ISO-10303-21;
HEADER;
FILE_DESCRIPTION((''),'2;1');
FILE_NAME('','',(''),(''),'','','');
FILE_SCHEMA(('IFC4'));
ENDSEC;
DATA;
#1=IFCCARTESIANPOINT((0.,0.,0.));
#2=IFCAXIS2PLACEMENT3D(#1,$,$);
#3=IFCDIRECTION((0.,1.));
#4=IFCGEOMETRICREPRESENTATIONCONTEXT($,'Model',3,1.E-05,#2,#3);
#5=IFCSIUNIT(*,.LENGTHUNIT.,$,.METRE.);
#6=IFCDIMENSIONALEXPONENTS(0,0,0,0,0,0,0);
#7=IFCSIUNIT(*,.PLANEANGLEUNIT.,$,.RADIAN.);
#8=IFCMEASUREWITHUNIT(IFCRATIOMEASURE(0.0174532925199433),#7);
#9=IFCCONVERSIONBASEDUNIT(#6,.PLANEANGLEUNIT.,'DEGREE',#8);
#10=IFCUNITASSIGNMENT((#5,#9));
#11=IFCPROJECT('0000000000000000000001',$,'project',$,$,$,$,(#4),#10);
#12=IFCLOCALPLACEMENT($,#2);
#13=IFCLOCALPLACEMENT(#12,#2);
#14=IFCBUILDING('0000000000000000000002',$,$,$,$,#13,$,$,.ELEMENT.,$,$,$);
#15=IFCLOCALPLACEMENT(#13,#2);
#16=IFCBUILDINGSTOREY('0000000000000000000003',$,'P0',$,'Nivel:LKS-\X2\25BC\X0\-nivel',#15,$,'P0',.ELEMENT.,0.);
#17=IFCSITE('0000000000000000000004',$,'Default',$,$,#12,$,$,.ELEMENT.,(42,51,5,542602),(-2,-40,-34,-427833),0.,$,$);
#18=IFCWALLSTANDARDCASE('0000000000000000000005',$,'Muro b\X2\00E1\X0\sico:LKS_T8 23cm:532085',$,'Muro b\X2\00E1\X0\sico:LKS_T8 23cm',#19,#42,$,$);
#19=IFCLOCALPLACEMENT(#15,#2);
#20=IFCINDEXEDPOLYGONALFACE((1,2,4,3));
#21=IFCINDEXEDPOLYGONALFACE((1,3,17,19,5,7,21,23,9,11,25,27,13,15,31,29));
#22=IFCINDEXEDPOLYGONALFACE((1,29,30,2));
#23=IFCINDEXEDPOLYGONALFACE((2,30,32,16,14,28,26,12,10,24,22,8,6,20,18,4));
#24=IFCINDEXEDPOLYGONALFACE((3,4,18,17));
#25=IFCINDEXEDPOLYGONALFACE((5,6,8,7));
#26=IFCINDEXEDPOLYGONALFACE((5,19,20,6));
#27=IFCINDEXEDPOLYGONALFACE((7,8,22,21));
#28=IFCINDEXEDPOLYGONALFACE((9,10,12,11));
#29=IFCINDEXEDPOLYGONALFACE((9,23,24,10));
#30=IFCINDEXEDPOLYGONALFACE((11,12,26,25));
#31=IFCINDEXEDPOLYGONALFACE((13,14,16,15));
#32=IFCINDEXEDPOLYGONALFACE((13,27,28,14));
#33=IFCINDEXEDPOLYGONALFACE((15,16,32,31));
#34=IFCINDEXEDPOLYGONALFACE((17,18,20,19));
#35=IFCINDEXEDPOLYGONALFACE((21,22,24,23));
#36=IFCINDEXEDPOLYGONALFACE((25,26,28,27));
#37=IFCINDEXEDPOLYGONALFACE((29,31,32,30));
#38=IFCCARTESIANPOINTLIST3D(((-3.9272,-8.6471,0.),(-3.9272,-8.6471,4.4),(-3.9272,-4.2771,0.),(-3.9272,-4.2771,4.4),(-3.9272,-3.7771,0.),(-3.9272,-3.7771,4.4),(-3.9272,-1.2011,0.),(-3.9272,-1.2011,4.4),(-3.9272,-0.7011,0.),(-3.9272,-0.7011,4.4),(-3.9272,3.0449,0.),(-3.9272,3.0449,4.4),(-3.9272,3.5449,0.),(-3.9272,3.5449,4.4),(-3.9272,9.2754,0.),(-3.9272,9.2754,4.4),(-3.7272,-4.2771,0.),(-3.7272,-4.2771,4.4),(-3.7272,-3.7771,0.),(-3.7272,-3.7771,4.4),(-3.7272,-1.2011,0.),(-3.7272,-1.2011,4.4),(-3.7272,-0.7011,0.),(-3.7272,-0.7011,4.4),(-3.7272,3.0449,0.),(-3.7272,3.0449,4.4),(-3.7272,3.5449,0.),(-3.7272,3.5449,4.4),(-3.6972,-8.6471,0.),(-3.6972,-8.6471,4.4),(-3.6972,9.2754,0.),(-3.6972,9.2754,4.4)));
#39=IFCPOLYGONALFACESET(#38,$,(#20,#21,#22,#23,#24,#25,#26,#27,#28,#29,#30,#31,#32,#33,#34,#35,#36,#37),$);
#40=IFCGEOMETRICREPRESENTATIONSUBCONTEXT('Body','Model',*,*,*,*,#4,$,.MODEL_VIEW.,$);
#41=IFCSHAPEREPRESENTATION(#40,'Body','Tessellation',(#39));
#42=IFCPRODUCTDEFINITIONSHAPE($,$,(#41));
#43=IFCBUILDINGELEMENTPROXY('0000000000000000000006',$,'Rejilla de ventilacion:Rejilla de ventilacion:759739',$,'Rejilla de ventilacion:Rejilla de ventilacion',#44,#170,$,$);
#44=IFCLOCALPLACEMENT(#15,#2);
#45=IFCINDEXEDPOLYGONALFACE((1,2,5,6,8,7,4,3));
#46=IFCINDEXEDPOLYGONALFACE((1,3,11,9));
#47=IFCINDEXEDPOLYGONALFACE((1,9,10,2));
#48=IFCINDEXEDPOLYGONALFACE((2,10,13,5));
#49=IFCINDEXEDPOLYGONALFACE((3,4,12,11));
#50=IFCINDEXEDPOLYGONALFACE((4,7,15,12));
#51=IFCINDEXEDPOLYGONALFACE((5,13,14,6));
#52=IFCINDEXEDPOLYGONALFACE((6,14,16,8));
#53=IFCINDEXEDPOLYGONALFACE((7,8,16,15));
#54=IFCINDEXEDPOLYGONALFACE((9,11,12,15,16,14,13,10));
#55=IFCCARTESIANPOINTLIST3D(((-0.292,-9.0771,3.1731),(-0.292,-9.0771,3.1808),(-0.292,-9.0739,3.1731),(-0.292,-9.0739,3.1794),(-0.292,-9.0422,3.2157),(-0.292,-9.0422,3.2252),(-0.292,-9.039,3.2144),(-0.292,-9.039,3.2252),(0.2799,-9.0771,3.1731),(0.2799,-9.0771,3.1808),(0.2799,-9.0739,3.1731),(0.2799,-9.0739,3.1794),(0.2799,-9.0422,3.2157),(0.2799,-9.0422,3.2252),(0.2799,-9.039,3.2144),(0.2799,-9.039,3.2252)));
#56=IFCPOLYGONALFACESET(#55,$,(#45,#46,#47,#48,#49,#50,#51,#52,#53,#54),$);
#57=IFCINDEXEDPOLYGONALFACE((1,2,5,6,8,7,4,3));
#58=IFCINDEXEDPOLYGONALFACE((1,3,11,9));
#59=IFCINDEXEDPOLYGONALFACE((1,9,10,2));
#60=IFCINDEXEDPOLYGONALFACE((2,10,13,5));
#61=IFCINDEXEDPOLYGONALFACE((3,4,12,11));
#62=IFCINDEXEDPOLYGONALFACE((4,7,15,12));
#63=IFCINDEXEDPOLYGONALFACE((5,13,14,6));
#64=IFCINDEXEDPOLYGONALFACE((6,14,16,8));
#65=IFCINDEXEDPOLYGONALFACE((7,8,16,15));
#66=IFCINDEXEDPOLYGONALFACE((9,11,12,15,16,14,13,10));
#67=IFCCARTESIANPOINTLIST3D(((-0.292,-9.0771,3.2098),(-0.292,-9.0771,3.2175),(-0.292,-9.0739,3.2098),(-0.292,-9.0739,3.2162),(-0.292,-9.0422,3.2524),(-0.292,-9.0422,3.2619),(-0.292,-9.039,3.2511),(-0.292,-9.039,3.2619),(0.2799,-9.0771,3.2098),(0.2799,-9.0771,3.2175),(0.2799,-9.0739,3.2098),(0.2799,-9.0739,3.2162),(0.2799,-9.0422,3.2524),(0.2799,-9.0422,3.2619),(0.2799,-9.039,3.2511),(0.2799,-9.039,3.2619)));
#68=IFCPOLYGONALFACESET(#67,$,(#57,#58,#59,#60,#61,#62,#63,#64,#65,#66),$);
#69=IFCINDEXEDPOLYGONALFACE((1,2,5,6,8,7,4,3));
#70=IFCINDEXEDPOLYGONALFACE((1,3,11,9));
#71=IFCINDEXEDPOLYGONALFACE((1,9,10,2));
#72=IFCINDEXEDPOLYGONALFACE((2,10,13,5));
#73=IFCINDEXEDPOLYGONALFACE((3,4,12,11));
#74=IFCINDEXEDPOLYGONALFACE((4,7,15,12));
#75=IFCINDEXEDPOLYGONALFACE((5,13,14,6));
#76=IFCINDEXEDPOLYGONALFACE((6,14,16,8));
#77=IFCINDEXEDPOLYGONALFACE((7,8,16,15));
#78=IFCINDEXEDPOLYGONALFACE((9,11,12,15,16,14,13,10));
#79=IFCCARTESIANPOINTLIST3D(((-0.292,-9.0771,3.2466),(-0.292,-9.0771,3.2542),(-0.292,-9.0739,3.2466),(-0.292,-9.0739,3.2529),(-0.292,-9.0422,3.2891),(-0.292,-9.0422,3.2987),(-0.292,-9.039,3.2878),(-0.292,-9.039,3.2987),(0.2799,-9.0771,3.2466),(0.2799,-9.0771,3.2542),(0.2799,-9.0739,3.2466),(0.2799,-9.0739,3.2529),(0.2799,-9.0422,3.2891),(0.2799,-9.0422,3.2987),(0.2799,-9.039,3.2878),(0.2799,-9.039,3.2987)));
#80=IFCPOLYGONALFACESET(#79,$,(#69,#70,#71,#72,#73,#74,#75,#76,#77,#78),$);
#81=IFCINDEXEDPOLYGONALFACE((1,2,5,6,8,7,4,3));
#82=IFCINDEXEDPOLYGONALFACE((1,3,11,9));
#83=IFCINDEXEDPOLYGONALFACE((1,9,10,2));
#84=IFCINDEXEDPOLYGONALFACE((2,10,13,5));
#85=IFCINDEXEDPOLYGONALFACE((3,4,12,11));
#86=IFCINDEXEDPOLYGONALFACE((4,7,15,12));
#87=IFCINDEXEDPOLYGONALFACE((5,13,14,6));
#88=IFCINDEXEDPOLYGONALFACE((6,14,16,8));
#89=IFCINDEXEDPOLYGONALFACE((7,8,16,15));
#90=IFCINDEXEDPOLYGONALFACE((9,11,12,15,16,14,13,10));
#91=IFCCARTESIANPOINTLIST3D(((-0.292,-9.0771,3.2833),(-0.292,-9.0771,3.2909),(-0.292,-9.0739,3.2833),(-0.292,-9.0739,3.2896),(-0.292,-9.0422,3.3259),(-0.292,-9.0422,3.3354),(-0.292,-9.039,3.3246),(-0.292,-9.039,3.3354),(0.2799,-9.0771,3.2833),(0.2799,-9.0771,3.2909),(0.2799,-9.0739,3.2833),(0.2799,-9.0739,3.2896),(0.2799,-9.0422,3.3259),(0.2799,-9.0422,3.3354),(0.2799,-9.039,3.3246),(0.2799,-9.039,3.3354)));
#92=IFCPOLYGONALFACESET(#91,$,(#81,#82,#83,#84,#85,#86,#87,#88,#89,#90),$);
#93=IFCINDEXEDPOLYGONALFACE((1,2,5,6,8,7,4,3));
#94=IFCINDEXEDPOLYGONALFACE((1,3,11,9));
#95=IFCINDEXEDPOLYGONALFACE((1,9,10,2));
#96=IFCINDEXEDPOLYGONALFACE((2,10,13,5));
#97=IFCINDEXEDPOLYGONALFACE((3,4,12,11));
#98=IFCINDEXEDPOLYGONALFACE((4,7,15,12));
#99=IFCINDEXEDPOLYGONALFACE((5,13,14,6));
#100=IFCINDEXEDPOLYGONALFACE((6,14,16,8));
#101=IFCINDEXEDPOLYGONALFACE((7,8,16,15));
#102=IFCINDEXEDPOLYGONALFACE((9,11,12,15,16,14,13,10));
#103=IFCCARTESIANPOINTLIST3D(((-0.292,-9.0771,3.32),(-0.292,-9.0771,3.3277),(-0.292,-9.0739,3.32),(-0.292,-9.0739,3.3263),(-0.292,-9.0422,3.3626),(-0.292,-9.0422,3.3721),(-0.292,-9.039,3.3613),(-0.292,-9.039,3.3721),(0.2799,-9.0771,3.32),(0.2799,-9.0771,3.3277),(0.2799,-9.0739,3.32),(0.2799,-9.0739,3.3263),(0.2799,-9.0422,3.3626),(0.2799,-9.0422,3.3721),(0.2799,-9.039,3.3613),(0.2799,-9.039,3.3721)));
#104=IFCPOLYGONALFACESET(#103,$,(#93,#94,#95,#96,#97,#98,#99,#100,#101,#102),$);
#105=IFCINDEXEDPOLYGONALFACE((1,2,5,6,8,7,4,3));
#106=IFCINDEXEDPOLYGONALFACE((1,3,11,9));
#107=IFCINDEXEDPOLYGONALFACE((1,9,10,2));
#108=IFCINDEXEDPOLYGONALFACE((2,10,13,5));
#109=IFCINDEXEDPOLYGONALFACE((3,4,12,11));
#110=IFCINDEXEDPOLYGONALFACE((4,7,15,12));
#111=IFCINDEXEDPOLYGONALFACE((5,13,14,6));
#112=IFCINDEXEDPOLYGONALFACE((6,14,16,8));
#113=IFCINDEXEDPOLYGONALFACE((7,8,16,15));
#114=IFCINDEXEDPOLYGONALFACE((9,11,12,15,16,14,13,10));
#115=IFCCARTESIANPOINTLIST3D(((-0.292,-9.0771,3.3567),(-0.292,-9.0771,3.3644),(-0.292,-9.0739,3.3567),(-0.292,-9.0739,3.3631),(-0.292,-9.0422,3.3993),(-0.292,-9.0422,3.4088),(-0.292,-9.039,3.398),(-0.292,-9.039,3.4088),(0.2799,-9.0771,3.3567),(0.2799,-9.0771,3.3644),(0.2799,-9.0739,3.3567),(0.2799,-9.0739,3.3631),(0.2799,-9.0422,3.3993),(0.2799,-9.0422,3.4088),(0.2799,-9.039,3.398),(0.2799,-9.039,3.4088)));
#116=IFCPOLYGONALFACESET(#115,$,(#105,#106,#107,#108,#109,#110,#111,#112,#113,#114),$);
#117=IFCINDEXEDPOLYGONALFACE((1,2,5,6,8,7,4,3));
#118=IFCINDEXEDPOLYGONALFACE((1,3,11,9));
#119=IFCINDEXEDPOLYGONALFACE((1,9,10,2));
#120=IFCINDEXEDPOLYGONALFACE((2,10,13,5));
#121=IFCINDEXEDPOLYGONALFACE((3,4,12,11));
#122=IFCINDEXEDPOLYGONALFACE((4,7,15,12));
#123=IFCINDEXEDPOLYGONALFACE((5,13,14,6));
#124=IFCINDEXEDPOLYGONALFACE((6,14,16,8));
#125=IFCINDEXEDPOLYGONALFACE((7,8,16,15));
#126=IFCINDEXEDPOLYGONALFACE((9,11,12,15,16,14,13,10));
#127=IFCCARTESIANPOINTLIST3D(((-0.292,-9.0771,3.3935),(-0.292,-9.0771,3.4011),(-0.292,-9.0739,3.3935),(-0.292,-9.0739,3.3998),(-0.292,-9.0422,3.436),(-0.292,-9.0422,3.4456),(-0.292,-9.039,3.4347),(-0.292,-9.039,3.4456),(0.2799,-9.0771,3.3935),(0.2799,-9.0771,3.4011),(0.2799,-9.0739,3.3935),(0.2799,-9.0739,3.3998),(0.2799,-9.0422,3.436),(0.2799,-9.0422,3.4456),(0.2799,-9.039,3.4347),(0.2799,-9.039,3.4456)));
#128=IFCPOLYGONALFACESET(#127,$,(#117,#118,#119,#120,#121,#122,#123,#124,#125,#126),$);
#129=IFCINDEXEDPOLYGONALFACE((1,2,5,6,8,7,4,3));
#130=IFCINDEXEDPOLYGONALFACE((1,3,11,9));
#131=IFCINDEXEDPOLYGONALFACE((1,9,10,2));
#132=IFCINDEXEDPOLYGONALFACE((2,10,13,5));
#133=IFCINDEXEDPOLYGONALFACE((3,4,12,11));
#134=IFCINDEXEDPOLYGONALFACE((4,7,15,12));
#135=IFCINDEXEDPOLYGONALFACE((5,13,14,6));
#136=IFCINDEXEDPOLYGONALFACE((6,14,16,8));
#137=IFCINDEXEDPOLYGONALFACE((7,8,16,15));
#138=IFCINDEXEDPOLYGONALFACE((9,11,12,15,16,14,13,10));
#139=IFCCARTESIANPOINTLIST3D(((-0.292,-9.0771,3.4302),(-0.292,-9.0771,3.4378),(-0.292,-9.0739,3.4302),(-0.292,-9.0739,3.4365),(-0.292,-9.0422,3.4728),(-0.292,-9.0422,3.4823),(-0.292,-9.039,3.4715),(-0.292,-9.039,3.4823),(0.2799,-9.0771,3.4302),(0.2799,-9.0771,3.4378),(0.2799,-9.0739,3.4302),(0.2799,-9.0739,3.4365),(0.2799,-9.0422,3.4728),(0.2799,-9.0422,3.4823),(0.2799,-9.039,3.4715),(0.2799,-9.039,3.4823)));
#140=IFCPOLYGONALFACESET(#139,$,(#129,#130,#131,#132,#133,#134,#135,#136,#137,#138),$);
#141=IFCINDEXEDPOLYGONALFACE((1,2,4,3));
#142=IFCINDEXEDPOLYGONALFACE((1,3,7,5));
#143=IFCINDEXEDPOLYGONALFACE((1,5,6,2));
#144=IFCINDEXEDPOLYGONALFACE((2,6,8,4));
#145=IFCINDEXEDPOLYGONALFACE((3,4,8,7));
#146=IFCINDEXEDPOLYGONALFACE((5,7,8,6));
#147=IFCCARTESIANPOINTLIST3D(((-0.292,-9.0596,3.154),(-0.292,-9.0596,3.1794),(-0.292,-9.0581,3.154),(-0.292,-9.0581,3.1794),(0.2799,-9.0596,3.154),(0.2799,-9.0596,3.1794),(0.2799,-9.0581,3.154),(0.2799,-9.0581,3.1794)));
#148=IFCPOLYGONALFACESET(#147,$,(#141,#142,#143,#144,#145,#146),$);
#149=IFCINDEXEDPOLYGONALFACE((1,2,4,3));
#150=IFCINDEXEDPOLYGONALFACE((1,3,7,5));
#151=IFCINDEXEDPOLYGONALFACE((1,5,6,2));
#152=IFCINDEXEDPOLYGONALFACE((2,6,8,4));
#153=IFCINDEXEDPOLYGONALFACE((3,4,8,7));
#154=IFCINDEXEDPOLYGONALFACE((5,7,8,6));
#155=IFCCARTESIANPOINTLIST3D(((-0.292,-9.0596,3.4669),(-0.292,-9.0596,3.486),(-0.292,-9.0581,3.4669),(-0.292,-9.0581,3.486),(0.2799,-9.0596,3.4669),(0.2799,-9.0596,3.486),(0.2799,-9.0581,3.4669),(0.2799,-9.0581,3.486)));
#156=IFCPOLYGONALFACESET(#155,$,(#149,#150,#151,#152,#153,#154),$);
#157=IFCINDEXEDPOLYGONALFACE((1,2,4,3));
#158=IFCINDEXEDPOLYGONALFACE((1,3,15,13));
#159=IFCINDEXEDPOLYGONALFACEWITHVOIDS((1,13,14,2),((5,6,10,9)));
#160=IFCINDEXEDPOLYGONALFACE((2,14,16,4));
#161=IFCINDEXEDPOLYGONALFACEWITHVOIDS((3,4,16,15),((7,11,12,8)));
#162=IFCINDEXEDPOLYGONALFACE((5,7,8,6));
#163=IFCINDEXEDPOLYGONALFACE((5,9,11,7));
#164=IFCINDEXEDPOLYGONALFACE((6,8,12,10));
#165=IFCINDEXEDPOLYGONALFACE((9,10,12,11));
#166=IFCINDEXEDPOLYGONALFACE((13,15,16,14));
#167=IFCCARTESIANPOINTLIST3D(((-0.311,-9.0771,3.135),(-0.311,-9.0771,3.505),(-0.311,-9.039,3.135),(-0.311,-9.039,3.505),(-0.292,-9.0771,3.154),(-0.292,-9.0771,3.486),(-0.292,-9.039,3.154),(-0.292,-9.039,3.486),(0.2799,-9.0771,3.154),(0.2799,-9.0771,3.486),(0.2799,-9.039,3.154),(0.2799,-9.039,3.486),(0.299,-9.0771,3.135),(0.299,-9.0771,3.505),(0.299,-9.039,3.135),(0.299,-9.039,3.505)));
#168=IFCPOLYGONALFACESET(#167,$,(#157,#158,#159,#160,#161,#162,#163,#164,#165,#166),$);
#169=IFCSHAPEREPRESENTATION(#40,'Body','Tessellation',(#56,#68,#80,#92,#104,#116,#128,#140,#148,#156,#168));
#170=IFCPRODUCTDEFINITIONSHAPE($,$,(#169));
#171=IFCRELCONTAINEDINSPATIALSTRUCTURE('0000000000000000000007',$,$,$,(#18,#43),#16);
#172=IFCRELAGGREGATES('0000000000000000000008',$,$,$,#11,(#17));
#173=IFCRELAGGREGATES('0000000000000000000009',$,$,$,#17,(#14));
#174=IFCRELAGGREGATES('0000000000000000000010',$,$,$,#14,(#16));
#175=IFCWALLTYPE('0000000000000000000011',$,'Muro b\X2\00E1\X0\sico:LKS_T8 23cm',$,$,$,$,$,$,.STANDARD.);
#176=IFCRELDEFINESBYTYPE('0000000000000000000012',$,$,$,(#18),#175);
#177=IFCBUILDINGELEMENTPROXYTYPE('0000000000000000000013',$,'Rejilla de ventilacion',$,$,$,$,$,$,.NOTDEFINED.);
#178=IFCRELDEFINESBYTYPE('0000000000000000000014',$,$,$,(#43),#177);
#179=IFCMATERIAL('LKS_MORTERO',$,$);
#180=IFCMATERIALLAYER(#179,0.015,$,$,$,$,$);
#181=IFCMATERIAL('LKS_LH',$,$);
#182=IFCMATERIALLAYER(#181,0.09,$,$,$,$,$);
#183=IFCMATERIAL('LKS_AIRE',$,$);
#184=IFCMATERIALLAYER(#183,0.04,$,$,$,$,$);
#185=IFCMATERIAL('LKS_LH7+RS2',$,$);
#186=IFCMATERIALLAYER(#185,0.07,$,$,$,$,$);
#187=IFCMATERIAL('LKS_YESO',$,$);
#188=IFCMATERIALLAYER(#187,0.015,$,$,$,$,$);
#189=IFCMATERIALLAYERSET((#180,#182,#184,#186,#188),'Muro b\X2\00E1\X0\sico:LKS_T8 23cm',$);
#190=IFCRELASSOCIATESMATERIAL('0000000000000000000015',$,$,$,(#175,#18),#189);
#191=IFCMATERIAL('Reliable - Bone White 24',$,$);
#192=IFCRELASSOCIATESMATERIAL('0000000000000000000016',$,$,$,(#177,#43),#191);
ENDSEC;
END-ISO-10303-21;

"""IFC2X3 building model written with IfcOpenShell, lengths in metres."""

from ifc_helpers import new_model, entity, si_unit, converted_unit, direction, frame, frame_2d, origin, place, context, subcontext, project, spatial, polyline, rectangle, outline, extrude, clip, bounded_halfspace, source, transform, mapped, material, layer, layer_set, layer_usage, type_object, type_shapes, element, save


model = new_model("IFC2X3")

# Units and contexts
model_context = context("Model", 3, precision=1e-05, world=origin(), true_north=direction((0.0, 1.0)))
body_context = subcontext(model_context, "Body", "Model", "MODEL_VIEW")
ifc_project = project(units=[si_unit("LENGTHUNIT", "METRE"), converted_unit("PLANEANGLEUNIT", "DEGREE", entity("IfcRatioMeasure", 0.0174532925199433), si_unit("PLANEANGLEUNIT", "RADIAN"), dimensions=[0, 0, 0, 0, 0, 0, 0])], contexts=[model_context])

# Site, building, storey
site_placement = place(None, origin())
site = spatial("IfcSite", under=ifc_project, at=site_placement, Name="Default", CompositionType="ELEMENT", RefLatitude=(42, 51, 5, 542602), RefLongitude=(-2, -40, -34, -427833), RefElevation=0.0)
building_placement = place(site_placement, origin())
building = spatial("IfcBuilding", under=site, at=building_placement, CompositionType="ELEMENT")
storey_placement = place(building_placement, origin())
storey = spatial("IfcBuildingStorey", under=building, at=storey_placement, Name="P0", ObjectType="Nivel:LKS-▼-nivel", LongName="P0", CompositionType="ELEMENT", Elevation=0.0)

# Shared definitions
ifc_material_1 = material(Name="LKS_MORTERO")
ifc_layer_1 = layer(ifc_material_1, 0.015)
ifc_material_2 = material(Name="LKS_LH")
ifc_layer_2 = layer(ifc_material_2, 0.09)
ifc_material_3 = material(Name="LKS_AIRE")
ifc_layer_3 = layer(ifc_material_3, 0.04)
ifc_material_4 = material(Name="LKS_LH7+RS2")
ifc_layer_4 = layer(ifc_material_4, 0.07)
ifc_material_5 = material(Name="LKS_YESO")
ifc_layer_5 = layer(ifc_material_5, 0.015)
ifc_layer_set_1 = layer_set([ifc_layer_1, ifc_layer_2, ifc_layer_3, ifc_layer_4, ifc_layer_5], Name="Muro básico:LKS_T8 23cm")
wall_type_1 = type_object("IfcWallType", Name="Muro básico:LKS_T8 23cm", PredefinedType="STANDARD", material=ifc_layer_set_1)

# Wall, openings
ifc_layer_usage_1 = layer_usage(ifc_layer_set_1, "AXIS2", "NEGATIVE", 0.115)
wall_1_placement = place(storey_placement, frame((-3.8122, -8.6471, 0.0), z_axis=(0.0, 0.0, 1.0), x_axis=(0.0, 1.0, 0.0)))
wall_1 = element("IfcWallStandardCase", 1, at=wall_1_placement, inside=storey, type_object=wall_type_1, material=ifc_layer_usage_1, Name="Muro básico:LKS_T8 23cm:532085", ObjectType="Muro básico:LKS_T8 23cm", context=body_context, shape_type="Clipping", body=[
    clip(extrude(rectangle(XDim=17.9225, YDim=0.23, at=frame_2d((8.9613, 0.0), x_axis=(-1.0, 0.0))), origin(), (0.0, 0.0, 1.0), 4.4), bounded_halfspace(frame((0.0, -0.115, 0.0), z_axis=(1.0, 0.0, 0.0), x_axis=(0.0, 0.0, -1.0)), True, frame((0.0, -0.115, 0.0), z_axis=(1.0, 0.0, 0.0), x_axis=(0.0, 0.0, -1.0)), polyline([(0.0, 0.0), (0.0, 0.23), (-3.958, 0.23), (-4.4, 0.23), (-4.4, 0.0), (0.0, 0.0)]))),
])
opening_1_placement = place(storey_placement, frame((-3.8122, -8.6471, 0.0), z_axis=(0.0, 0.0, 1.0), x_axis=(0.0, 1.0, 0.0)))
element("IfcOpeningElement", 2, at=opening_1_placement, cuts=wall_1, ObjectType="Opening", context=body_context, shape_type="SweptSolid", body=[
    extrude(rectangle(XDim=4.4, YDim=0.2, at=frame_2d((0.586, 0.0), x_axis=(1.0, 0.0))), frame((4.37, 0.015, 2.786), z_axis=(1.0, 0.0, 0.0), x_axis=(0.0, 0.0, -1.0)), (0.0, 0.0, 1.0), 0.5),
])
opening_2_placement = place(storey_placement, frame((-3.8122, -8.6471, 0.0), z_axis=(0.0, 0.0, 1.0), x_axis=(0.0, 1.0, 0.0)))
element("IfcOpeningElement", 3, at=opening_2_placement, cuts=wall_1, ObjectType="Opening", context=body_context, shape_type="SweptSolid", body=[
    extrude(rectangle(XDim=4.4, YDim=0.2, at=frame_2d((0.586, 0.0), x_axis=(1.0, 0.0))), frame((7.446, 0.015, 2.786), z_axis=(1.0, 0.0, 0.0), x_axis=(0.0, 0.0, -1.0)), (0.0, 0.0, 1.0), 0.5),
])
opening_3_placement = place(storey_placement, frame((-3.8122, -8.6471, 0.0), z_axis=(0.0, 0.0, 1.0), x_axis=(0.0, 1.0, 0.0)))
element("IfcOpeningElement", 4, at=opening_3_placement, cuts=wall_1, ObjectType="Opening", context=body_context, shape_type="SweptSolid", body=[
    extrude(rectangle(XDim=4.4, YDim=0.2, at=frame_2d((0.586, 0.0), x_axis=(1.0, 0.0))), frame((11.692, 0.015, 2.786), z_axis=(1.0, 0.0, 0.0), x_axis=(0.0, 0.0, -1.0)), (0.0, 0.0, 1.0), 0.5),
])

# Building element proxy
ifc_material_6 = material(Name="Reliable - Bone White 24")
building_element_proxy_type_1 = type_object("IfcBuildingElementProxyType", Name="Rejilla de ventilacion", PredefinedType="NOTDEFINED", material=ifc_material_6)
shared_shape_1 = source(origin(), body_context, "Body", "SweptSolid", [
    extrude(outline(polyline([(0.0173, 0.0159), (0.0269, 0.0159), (0.0269, 0.0191), (0.016, 0.0191), (-0.0189, -0.0159), (-0.0253, -0.0159), (-0.0253, -0.019), (-0.0176, -0.019), (0.0173, 0.0159)])), frame((-0.2859, 0.126, 1.2174), z_axis=(1.0, 0.0, 0.0), x_axis=(0.0, 0.0, 1.0)), (0.0, 0.0, 1.0), 0.5719),
    extrude(outline(polyline([(0.0173, 0.0159), (0.0269, 0.0159), (0.0269, 0.0191), (0.016, 0.0191), (-0.0189, -0.0159), (-0.0253, -0.0159), (-0.0253, -0.019), (-0.0176, -0.019), (0.0173, 0.0159)])), frame((-0.2859, 0.126, 1.2541), z_axis=(1.0, 0.0, 0.0), x_axis=(0.0, 0.0, 1.0)), (0.0, 0.0, 1.0), 0.5719),
    extrude(outline(polyline([(0.0173, 0.0159), (0.0269, 0.0159), (0.0269, 0.0191), (0.016, 0.0191), (-0.0189, -0.0159), (-0.0253, -0.0159), (-0.0253, -0.019), (-0.0176, -0.019), (0.0173, 0.0159)])), frame((-0.2859, 0.126, 1.2908), z_axis=(1.0, 0.0, 0.0), x_axis=(0.0, 0.0, 1.0)), (0.0, 0.0, 1.0), 0.5719),
    extrude(outline(polyline([(0.0173, 0.0159), (0.0269, 0.0159), (0.0269, 0.0191), (0.016, 0.0191), (-0.0189, -0.0159), (-0.0253, -0.0159), (-0.0253, -0.019), (-0.0176, -0.019), (0.0173, 0.0159)])), frame((-0.2859, 0.126, 1.3275), z_axis=(1.0, 0.0, 0.0), x_axis=(0.0, 0.0, 1.0)), (0.0, 0.0, 1.0), 0.5719),
    extrude(outline(polyline([(0.0173, 0.0159), (0.0269, 0.0159), (0.0269, 0.0191), (0.016, 0.0191), (-0.0189, -0.0159), (-0.0253, -0.0159), (-0.0253, -0.019), (-0.0176, -0.019), (0.0173, 0.0159)])), frame((-0.2859, 0.126, 1.3643), z_axis=(1.0, 0.0, 0.0), x_axis=(0.0, 0.0, 1.0)), (0.0, 0.0, 1.0), 0.5719),
    extrude(outline(polyline([(0.0173, 0.0159), (0.0269, 0.0159), (0.0269, 0.0191), (0.016, 0.0191), (-0.0189, -0.0159), (-0.0253, -0.0159), (-0.0253, -0.019), (-0.0176, -0.019), (0.0173, 0.0159)])), frame((-0.2859, 0.126, 1.401), z_axis=(1.0, 0.0, 0.0), x_axis=(0.0, 0.0, 1.0)), (0.0, 0.0, 1.0), 0.5719),
    extrude(outline(polyline([(0.0173, 0.0159), (0.0269, 0.0159), (0.0269, 0.0191), (0.016, 0.0191), (-0.0189, -0.0159), (-0.0253, -0.0159), (-0.0253, -0.019), (-0.0176, -0.019), (0.0173, 0.0159)])), frame((-0.2859, 0.126, 1.4377), z_axis=(1.0, 0.0, 0.0), x_axis=(0.0, 0.0, 1.0)), (0.0, 0.0, 1.0), 0.5719),
    extrude(outline(polyline([(0.0173, 0.0159), (0.0269, 0.0159), (0.0269, 0.0191), (0.016, 0.0191), (-0.0189, -0.0159), (-0.0253, -0.0159), (-0.0253, -0.019), (-0.0176, -0.019), (0.0173, 0.0159)])), frame((-0.2859, 0.126, 1.4744), z_axis=(1.0, 0.0, 0.0), x_axis=(0.0, 0.0, 1.0)), (0.0, 0.0, 1.0), 0.5719),
    extrude(rectangle(XDim=0.5719, YDim=0.0016, at=frame_2d((0.0, 0.0), x_axis=(1.0, 0.0))), frame((0.0, 0.1267, 1.173), z_axis=(0.0, 0.0, 1.0), x_axis=(-1.0, 0.0, 0.0)), (0.0, 0.0, 1.0), 0.0254),
    extrude(rectangle(XDim=0.5719, YDim=0.0016, at=frame_2d((0.0, 0.0), x_axis=(1.0, 0.0))), frame((0.0, 0.1267, 1.4859), z_axis=(0.0, 0.0, 1.0), x_axis=(-1.0, 0.0, 0.0)), (0.0, 0.0, 1.0), 0.0191),
    extrude(outline(polyline([(-0.185, -0.305), (0.185, -0.305), (0.185, 0.305), (-0.185, 0.305), (-0.185, -0.305)]), holes=[polyline([(-0.166, -0.286), (-0.166, 0.286), (0.166, 0.286), (0.166, -0.286), (-0.166, -0.286)])]), frame((0.0, 0.1069, 1.339), z_axis=(0.0, 1.0, 0.0), x_axis=(0.0, 0.0, 1.0)), (0.0, 0.0, 1.0), 0.0381),
])
type_shapes(building_element_proxy_type_1, [shared_shape_1])
for number, where, z_axis, x_axis, name in (
    (5, (-0.006, -8.9321, 1.981), (0.0, 0.0, 1.0), (-1.0, 0.0, 0.0), "Rejilla de ventilacion:Rejilla de ventilacion:759739"),
):
    element("IfcBuildingElementProxy", number, at=place(storey_placement, frame(where, z_axis=z_axis, x_axis=x_axis)), inside=storey, type_object=building_element_proxy_type_1, material=ifc_material_6, Name=name, ObjectType="Rejilla de ventilacion:Rejilla de ventilacion", context=body_context, shape_type="MappedRepresentation", body=[
        mapped(shared_shape_1, transform((0.0, 0.0, 0.0), scale=1.0)),
    ])

save(model, "model.ifc")
